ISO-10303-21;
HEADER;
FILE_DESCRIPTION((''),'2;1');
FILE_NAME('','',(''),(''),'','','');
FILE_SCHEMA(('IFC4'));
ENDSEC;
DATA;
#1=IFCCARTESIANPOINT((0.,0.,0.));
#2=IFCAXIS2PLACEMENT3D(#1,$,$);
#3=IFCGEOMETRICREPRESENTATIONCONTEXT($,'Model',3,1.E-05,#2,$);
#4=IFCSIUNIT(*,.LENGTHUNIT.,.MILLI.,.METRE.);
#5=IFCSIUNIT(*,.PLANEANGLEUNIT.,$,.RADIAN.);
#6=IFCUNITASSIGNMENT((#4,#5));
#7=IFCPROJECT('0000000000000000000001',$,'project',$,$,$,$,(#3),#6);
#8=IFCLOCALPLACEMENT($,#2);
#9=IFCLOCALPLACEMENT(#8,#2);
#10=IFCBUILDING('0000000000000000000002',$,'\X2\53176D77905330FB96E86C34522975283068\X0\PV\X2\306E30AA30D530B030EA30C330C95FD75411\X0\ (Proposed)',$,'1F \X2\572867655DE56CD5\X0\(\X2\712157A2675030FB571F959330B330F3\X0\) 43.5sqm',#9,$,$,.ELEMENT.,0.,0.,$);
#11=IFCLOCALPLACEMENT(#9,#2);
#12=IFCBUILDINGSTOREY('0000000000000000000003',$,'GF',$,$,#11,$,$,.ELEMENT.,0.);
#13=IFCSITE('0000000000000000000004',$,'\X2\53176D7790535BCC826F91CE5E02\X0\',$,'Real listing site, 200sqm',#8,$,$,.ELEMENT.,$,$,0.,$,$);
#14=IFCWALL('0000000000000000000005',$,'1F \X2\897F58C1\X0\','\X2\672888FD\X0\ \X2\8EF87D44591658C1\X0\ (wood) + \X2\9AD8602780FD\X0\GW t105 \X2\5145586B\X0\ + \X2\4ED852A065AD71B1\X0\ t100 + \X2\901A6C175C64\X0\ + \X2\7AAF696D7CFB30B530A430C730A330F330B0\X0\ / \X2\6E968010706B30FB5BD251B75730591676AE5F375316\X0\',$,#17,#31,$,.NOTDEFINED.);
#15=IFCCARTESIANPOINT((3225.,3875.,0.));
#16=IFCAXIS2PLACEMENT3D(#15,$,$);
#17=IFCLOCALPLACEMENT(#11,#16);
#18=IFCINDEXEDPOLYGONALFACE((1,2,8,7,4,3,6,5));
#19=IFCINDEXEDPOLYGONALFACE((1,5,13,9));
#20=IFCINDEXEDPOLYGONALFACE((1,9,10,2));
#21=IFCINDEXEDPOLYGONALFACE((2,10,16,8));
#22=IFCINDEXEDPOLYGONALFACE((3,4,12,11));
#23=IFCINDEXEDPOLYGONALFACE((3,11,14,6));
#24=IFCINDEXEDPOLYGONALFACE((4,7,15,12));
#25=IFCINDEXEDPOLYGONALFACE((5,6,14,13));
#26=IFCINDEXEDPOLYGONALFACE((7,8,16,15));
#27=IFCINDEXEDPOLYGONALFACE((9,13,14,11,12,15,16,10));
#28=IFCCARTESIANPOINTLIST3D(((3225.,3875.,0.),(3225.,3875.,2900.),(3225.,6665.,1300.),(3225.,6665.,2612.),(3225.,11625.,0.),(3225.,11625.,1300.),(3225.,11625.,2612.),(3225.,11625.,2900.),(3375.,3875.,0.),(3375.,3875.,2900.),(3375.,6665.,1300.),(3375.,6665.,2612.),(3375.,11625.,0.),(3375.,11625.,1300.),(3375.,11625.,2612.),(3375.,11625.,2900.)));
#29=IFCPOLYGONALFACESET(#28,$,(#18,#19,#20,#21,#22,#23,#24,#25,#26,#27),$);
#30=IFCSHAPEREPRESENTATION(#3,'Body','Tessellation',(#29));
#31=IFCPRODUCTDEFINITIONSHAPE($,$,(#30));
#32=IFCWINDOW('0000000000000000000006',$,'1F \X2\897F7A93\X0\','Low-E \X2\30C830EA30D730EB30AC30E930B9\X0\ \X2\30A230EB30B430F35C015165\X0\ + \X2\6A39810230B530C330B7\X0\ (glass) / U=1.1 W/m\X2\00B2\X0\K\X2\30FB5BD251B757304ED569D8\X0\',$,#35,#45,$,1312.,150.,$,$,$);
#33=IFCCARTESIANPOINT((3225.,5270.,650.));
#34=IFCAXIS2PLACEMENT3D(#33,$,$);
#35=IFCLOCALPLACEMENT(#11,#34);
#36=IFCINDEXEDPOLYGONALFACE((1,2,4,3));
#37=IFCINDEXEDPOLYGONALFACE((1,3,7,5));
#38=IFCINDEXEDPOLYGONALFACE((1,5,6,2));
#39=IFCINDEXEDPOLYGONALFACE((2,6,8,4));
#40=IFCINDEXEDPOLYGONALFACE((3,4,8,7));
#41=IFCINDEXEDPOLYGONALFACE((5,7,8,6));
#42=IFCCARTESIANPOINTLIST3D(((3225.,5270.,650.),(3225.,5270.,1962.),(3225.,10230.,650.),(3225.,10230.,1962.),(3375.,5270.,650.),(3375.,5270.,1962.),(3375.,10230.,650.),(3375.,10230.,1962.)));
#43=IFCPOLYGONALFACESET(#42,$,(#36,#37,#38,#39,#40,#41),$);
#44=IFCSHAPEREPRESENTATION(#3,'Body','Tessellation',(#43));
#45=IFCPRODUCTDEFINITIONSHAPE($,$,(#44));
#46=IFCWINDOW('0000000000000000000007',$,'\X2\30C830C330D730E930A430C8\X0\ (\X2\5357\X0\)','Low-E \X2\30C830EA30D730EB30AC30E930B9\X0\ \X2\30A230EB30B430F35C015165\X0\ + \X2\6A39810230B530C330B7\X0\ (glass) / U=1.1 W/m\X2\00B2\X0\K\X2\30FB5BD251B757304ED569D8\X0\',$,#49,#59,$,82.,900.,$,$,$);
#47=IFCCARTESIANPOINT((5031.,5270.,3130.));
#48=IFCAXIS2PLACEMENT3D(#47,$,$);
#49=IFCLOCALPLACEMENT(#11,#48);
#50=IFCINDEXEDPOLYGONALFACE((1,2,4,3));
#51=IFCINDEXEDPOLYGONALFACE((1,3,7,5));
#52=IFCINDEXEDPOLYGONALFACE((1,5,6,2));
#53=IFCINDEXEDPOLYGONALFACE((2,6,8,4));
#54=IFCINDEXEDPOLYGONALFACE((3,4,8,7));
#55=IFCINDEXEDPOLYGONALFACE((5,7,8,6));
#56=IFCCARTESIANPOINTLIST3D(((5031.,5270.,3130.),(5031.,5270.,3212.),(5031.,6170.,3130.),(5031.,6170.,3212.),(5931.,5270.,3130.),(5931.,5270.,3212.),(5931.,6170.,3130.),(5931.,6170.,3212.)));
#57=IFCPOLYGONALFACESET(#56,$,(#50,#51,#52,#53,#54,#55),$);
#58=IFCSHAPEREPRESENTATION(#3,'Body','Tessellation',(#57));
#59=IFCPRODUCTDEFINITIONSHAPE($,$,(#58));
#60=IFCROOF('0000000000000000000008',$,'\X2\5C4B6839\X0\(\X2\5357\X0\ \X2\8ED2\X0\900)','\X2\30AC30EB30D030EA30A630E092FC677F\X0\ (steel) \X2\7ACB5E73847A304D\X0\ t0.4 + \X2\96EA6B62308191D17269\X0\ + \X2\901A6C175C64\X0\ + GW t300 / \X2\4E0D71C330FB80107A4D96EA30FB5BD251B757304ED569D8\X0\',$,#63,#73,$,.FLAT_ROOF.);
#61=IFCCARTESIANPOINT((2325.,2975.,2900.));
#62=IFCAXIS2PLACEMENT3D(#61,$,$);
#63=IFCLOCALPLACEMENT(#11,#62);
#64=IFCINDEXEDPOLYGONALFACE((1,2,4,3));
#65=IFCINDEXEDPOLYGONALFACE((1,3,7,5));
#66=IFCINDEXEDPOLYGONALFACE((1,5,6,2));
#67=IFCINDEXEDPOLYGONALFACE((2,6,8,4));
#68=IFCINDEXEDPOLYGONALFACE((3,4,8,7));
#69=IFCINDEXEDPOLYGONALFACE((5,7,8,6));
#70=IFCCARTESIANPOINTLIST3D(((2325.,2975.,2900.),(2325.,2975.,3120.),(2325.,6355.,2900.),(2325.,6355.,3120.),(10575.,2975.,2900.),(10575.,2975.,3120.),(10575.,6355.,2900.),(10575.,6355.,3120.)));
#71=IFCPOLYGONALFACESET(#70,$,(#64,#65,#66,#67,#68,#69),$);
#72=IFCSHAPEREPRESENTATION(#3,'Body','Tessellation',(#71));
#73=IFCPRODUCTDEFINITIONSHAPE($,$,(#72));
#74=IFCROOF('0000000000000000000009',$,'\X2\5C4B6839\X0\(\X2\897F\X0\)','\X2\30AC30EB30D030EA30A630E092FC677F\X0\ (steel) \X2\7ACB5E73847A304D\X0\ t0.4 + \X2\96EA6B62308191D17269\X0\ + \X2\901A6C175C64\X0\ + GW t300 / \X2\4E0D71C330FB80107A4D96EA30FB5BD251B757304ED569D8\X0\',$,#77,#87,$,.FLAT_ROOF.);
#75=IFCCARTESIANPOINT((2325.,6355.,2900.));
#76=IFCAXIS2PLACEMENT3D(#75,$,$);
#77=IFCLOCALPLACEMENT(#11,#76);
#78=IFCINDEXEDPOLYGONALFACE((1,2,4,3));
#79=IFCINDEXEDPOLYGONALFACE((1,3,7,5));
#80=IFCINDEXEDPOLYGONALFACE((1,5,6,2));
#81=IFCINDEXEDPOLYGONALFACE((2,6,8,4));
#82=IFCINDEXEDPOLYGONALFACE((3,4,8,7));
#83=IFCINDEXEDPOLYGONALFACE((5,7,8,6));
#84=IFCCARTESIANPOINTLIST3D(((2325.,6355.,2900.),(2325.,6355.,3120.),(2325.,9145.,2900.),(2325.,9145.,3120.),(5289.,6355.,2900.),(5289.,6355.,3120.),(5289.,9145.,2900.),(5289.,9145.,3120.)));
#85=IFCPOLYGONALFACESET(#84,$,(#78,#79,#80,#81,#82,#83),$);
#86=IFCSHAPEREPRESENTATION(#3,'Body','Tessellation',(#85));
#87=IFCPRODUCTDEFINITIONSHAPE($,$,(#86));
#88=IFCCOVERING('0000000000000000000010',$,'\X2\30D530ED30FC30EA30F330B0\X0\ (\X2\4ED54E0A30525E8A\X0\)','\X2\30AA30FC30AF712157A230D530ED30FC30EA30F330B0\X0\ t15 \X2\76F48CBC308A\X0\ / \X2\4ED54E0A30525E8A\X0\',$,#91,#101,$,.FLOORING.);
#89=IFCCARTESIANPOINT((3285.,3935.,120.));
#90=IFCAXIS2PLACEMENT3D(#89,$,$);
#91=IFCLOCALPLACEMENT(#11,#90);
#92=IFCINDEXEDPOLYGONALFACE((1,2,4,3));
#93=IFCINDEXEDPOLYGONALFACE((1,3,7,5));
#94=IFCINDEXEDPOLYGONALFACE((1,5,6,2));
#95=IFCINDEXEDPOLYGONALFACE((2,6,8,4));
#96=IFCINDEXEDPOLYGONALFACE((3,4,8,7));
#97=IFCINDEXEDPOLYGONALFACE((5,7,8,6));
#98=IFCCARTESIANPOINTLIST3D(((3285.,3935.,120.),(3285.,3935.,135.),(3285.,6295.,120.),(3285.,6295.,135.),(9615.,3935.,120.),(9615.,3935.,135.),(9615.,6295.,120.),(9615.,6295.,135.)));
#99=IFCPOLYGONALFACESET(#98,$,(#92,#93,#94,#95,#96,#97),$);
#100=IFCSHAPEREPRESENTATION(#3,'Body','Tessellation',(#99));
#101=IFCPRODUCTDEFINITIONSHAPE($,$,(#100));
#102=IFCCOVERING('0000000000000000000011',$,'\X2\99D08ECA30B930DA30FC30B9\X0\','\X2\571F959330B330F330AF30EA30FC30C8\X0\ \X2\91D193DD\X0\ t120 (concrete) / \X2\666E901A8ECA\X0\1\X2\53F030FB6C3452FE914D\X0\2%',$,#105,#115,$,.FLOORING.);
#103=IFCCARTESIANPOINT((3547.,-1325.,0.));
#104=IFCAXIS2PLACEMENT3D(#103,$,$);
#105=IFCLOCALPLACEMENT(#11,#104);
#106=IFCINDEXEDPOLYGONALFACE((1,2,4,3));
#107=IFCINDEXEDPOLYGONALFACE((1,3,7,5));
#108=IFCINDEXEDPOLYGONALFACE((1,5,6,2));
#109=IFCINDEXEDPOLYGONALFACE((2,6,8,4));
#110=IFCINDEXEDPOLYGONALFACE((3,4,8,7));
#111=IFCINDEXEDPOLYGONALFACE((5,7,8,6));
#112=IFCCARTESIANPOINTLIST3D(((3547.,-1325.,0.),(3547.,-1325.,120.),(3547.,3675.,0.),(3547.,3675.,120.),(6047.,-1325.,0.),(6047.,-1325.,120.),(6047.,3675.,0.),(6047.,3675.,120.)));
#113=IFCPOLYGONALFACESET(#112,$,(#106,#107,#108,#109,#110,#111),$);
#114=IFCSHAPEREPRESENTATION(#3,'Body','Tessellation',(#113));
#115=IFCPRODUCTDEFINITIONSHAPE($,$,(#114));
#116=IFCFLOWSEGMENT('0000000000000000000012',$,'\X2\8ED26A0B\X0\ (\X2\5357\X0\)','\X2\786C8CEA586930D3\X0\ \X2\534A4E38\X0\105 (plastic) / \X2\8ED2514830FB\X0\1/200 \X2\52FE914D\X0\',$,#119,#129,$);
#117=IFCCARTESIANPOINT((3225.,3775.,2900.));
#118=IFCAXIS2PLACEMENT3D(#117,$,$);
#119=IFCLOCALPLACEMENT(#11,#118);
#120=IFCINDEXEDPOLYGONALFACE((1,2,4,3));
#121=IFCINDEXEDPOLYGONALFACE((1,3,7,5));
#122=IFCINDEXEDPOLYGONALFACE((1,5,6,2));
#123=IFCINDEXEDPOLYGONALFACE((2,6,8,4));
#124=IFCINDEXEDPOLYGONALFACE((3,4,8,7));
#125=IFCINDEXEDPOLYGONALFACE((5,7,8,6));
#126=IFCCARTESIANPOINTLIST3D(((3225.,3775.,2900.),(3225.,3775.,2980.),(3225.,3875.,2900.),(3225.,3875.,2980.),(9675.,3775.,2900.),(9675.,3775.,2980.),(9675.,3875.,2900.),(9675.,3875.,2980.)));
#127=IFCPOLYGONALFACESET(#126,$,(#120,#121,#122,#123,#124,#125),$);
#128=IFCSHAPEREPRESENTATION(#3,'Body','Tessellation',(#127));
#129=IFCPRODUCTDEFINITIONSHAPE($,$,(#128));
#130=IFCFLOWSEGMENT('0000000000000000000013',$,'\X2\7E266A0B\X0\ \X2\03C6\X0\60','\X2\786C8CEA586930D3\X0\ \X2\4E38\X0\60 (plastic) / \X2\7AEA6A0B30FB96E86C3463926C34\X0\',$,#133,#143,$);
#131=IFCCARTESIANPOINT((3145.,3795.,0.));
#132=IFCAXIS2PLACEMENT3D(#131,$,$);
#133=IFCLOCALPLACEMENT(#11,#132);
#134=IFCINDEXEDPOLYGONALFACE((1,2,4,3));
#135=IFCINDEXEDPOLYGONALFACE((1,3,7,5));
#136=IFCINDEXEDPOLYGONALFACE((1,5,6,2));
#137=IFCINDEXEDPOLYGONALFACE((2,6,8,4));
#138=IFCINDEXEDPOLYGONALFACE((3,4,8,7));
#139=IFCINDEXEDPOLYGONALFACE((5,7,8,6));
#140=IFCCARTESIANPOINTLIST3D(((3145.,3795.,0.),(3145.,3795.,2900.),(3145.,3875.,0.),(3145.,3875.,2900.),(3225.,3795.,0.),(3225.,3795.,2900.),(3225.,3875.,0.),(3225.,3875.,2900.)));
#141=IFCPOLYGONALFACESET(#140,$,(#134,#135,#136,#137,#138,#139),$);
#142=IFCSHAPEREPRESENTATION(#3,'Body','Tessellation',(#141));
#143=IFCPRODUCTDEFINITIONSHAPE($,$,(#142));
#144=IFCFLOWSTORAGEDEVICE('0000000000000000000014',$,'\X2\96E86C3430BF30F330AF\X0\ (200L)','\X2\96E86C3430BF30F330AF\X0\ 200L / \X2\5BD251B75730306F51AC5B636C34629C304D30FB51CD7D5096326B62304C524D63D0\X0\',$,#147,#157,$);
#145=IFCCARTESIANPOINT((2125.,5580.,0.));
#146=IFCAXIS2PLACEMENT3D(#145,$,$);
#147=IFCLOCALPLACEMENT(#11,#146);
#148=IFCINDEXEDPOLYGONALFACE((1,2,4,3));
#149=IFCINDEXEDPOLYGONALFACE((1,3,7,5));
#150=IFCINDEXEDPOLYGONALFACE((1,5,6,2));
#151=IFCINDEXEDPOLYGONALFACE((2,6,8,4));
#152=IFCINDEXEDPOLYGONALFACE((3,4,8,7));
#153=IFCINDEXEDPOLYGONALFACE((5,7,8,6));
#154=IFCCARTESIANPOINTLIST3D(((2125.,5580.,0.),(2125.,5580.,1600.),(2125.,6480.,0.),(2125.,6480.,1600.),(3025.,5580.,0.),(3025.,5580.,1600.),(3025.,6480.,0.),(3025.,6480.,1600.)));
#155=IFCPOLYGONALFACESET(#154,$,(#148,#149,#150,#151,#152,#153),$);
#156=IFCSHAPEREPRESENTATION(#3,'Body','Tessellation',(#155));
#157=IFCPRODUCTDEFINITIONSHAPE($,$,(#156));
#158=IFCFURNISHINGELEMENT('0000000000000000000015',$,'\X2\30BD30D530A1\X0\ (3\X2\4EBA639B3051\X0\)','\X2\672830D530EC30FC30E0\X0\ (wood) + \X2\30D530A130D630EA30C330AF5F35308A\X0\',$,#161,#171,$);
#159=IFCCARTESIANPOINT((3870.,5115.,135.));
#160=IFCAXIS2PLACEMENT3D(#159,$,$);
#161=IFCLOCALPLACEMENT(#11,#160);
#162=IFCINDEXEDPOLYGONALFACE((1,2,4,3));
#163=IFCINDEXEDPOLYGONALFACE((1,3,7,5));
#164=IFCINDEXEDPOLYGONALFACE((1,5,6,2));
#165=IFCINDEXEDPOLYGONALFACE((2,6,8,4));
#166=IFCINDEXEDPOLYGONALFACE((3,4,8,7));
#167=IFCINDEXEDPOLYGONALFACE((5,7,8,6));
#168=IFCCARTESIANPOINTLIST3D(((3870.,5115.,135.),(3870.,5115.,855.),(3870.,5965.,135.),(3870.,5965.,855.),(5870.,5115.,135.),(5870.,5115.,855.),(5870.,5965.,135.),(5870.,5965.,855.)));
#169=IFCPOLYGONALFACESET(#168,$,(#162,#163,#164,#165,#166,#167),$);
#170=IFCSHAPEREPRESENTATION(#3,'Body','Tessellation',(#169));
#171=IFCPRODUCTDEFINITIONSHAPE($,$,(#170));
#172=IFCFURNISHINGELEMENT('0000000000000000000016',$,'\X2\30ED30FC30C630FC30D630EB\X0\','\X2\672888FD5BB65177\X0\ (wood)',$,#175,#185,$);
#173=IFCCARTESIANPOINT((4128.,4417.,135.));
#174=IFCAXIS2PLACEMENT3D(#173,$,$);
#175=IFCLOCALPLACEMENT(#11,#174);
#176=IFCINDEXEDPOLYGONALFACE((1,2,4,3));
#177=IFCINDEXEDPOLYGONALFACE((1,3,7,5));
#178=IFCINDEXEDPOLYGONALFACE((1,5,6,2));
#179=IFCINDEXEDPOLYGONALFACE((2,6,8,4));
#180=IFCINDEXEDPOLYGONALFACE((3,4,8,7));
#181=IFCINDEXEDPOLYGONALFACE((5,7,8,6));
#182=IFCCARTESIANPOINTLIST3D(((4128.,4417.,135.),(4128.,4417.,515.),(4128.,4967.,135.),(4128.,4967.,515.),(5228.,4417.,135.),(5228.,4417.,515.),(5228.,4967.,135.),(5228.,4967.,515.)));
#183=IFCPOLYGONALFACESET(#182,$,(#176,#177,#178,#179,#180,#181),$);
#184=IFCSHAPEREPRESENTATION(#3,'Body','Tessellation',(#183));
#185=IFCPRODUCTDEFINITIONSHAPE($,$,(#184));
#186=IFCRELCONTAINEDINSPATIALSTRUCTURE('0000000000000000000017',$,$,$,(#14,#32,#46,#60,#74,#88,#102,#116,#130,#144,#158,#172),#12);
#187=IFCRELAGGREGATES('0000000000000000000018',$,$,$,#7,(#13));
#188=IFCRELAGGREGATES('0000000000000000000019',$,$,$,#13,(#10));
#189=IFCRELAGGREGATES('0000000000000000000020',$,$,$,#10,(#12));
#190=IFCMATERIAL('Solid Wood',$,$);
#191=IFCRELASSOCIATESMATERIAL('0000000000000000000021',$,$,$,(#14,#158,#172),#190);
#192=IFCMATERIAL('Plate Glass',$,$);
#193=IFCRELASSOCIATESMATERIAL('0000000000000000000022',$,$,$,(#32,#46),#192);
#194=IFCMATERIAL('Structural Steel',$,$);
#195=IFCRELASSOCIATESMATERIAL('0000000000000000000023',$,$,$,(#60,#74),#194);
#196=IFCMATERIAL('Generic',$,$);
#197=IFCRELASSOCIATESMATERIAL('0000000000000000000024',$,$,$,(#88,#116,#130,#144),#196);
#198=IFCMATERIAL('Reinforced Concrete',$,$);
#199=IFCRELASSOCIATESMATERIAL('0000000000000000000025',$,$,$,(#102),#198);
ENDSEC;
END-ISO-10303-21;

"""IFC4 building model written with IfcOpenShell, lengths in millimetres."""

from ifc_helpers import new_model, si_unit, frame, frame_2d, origin, place, context, project, spatial, rectangle, extrude, material, element, fill, save


model = new_model("IFC4")

# Units and contexts
model_context = context("Model", 3, precision=1e-05, world=origin())
ifc_project = project(units=[si_unit("LENGTHUNIT", "METRE", prefix="MILLI"), si_unit("PLANEANGLEUNIT", "RADIAN")], contexts=[model_context])

# Site, building, storey
site_placement = place(None, origin())
site = spatial("IfcSite", under=ifc_project, at=site_placement, Name="北海道富良野市", ObjectType="Real listing site, 200sqm", CompositionType="ELEMENT", RefElevation=0.0)
building_placement = place(site_placement, origin())
building = spatial("IfcBuilding", under=site, at=building_placement, Name="北海道・雨水利用とPVのオフグリッド志向 (Proposed)", ObjectType="1F 在来工法(無垢材・土間コン) 43.5sqm", CompositionType="ELEMENT", ElevationOfRefHeight=0.0, ElevationOfTerrain=0.0)
storey_placement = place(building_placement, origin())
storey = spatial("IfcBuildingStorey", under=building, at=storey_placement, Name="GF", CompositionType="ELEMENT", Elevation=0.0)

# Shared definitions
ifc_material_1 = material(Name="Solid Wood")

# Shared definitions
ifc_material_2 = material(Name="Reinforced Concrete")

# Shared definitions
ifc_material_3 = material(Name="Plate Glass")

# Wall, opening, window
wall_1_placement = place(storey_placement, frame((3225.0, 3875.0, 0.0)))
wall_1 = element("IfcWall", 1, at=wall_1_placement, inside=storey, material=ifc_material_1, Name="1F 西壁", Description="木製 軸組外壁 (wood) + 高性能GW t105 充填 + 付加断熱 t100 + 通気層 + 窯業系サイディング / 準耐火・寒冷地外皮強化", PredefinedType="NOTDEFINED", context=model_context, shape_type="SweptSolid", body=[
    extrude(rectangle(XDim=150.0, YDim=7750.0, at=frame_2d((75.0, 3875.0))), frame((3225.0, 3875.0, 0.0)), (0.0, 0.0, 1.0), 2900.0),
])
opening_1_placement = place(storey_placement, frame((3225.0, 5270.0, 650.0)))
opening_1 = element("IfcOpeningElement", 2, at=opening_1_placement, cuts=wall_1, PredefinedType="NOTDEFINED", context=model_context, shape_type="SweptSolid", body=[
    extrude(rectangle(XDim=150.0, YDim=4960.0, at=frame_2d((75.0, 2480.0))), frame((3225.0, 5270.0, 650.0)), (0.0, 0.0, 1.0), 1312.0),
])
window_1_placement = place(storey_placement, frame((3225.0, 5270.0, 650.0)))
window_1 = element("IfcWindow", 3, at=window_1_placement, inside=storey, material=ifc_material_3, Name="1F 西窓", Description="Low-E トリプルガラス アルゴン封入 + 樹脂サッシ (glass) / U=1.1 W/m²K・寒冷地仕様", OverallHeight=1312.0, OverallWidth=150.0, context=model_context, shape_type="SweptSolid", body=[
    extrude(rectangle(XDim=150.0, YDim=4960.0, at=frame_2d((75.0, 2480.0))), frame((3225.0, 5270.0, 650.0)), (0.0, 0.0, 1.0), 1312.0),
])
fill(opening_1, window_1)

# Window
window_2_placement = place(storey_placement, frame((5031.0, 5270.0, 3130.0)))
element("IfcWindow", 4, at=window_2_placement, inside=storey, material=ifc_material_3, Name="トップライト (南)", Description="Low-E トリプルガラス アルゴン封入 + 樹脂サッシ (glass) / U=1.1 W/m²K・寒冷地仕様", OverallHeight=82.0, OverallWidth=900.0, context=model_context, shape_type="SweptSolid", body=[
    extrude(rectangle(XDim=900.0, YDim=900.0, at=frame_2d((450.0, 450.0))), frame((5031.0, 5270.0, 3130.0)), (0.0, 0.0, 1.0), 82.0),
])

# Roofs
ifc_material_4 = material(Name="Structural Steel")
roof_1_placement = place(storey_placement, frame((2325.0, 2975.0, 2900.0)))
element("IfcRoof", 5, at=roof_1_placement, inside=storey, material=ifc_material_4, Name="屋根(南 軒900)", Description="ガルバリウム鋼板 (steel) 立平葺き t0.4 + 雪止め金物 + 通気層 + GW t300 / 不燃・耐積雪・寒冷地仕様", PredefinedType="FLAT_ROOF", context=model_context, shape_type="SweptSolid", body=[
    extrude(rectangle(XDim=8250.0, YDim=3380.0, at=frame_2d((4125.0, 1690.0))), frame((2325.0, 2975.0, 2900.0)), (0.0, 0.0, 1.0), 220.0),
])
roof_2_placement = place(storey_placement, frame((2325.0, 6355.0, 2900.0)))
element("IfcRoof", 6, at=roof_2_placement, inside=storey, material=ifc_material_4, Name="屋根(西)", Description="ガルバリウム鋼板 (steel) 立平葺き t0.4 + 雪止め金物 + 通気層 + GW t300 / 不燃・耐積雪・寒冷地仕様", PredefinedType="FLAT_ROOF", context=model_context, shape_type="SweptSolid", body=[
    extrude(rectangle(XDim=2964.0, YDim=2790.0, at=frame_2d((1482.0, 1395.0))), frame((2325.0, 6355.0, 2900.0)), (0.0, 0.0, 1.0), 220.0),
])

# Coverings
ifc_material_5 = material(Name="Generic")
covering_1_placement = place(storey_placement, frame((3285.0, 3935.0, 120.0)))
element("IfcCovering", 7, at=covering_1_placement, inside=storey, material=ifc_material_5, Name="フローリング (仕上げ床)", Description="オーク無垢フローリング t15 直貼り / 仕上げ床", PredefinedType="FLOORING", context=model_context, shape_type="SweptSolid", body=[
    extrude(rectangle(XDim=6330.0, YDim=2360.0, at=frame_2d((3165.0, 1180.0))), frame((3285.0, 3935.0, 120.0)), (0.0, 0.0, 1.0), 15.0),
])
covering_2_placement = place(storey_placement, frame((3547.0, -1325.0, 0.0)))
element("IfcCovering", 8, at=covering_2_placement, inside=storey, material=ifc_material_2, Name="駐車スペース", Description="土間コンクリート 金鏝 t120 (concrete) / 普通車1台・水勾配2%", PredefinedType="FLOORING", context=model_context, shape_type="SweptSolid", body=[
    extrude(rectangle(XDim=2500.0, YDim=5000.0, at=frame_2d((1250.0, 2500.0))), frame((3547.0, -1325.0, 0.0)), (0.0, 0.0, 1.0), 120.0),
])

# Flow segments
flow_segment_1_placement = place(storey_placement, frame((3225.0, 3775.0, 2900.0)))
element("IfcFlowSegment", 9, at=flow_segment_1_placement, inside=storey, material=ifc_material_5, Name="軒樋 (南)", Description="硬質塩ビ 半丸105 (plastic) / 軒先・1/200 勾配", context=model_context, shape_type="SweptSolid", body=[
    extrude(rectangle(XDim=6450.0, YDim=100.0, at=frame_2d((3225.0, 50.0))), frame((3225.0, 3775.0, 2900.0)), (0.0, 0.0, 1.0), 80.0),
])
flow_segment_2_placement = place(storey_placement, frame((3145.0, 3795.0, 0.0)))
element("IfcFlowSegment", 10, at=flow_segment_2_placement, inside=storey, material=ifc_material_5, Name="縦樋 φ60", Description="硬質塩ビ 丸60 (plastic) / 竪樋・雨水排水", context=model_context, shape_type="SweptSolid", body=[
    extrude(rectangle(XDim=80.0, YDim=80.0, at=frame_2d((40.0, 40.0))), frame((3145.0, 3795.0, 0.0)), (0.0, 0.0, 1.0), 2900.0),
])

# Flow storage device
flow_storage_device_placement = place(storey_placement, frame((2125.0, 5580.0, 0.0)))
element("IfcFlowStorageDevice", 11, at=flow_storage_device_placement, inside=storey, material=ifc_material_5, Name="雨水タンク (200L)", Description="雨水タンク 200L / 寒冷地は冬季水抜き・凍結防止が前提", context=model_context, shape_type="SweptSolid", body=[
    extrude(rectangle(XDim=900.0, YDim=900.0, at=frame_2d((450.0, 450.0))), frame((2125.0, 5580.0, 0.0)), (0.0, 0.0, 1.0), 1600.0),
])

# Furnishing elements
furnishing_1_placement = place(storey_placement, frame((3870.0, 5115.0, 135.0)))
element("IfcFurnishingElement", 12, at=furnishing_1_placement, inside=storey, material=ifc_material_1, Name="ソファ (3人掛け)", Description="木フレーム (wood) + ファブリック張り", context=model_context, shape_type="SweptSolid", body=[
    extrude(rectangle(XDim=2000.0, YDim=850.0, at=frame_2d((1000.0, 425.0))), frame((3870.0, 5115.0, 135.0)), (0.0, 0.0, 1.0), 720.0),
])
furnishing_2_placement = place(storey_placement, frame((4128.0, 4417.0, 135.0)))
element("IfcFurnishingElement", 13, at=furnishing_2_placement, inside=storey, material=ifc_material_1, Name="ローテーブル", Description="木製家具 (wood)", context=model_context, shape_type="SweptSolid", body=[
    extrude(rectangle(XDim=1100.0, YDim=550.0, at=frame_2d((550.0, 275.0))), frame((4128.0, 4417.0, 135.0)), (0.0, 0.0, 1.0), 380.0),
])

save(model, "model.ifc")
